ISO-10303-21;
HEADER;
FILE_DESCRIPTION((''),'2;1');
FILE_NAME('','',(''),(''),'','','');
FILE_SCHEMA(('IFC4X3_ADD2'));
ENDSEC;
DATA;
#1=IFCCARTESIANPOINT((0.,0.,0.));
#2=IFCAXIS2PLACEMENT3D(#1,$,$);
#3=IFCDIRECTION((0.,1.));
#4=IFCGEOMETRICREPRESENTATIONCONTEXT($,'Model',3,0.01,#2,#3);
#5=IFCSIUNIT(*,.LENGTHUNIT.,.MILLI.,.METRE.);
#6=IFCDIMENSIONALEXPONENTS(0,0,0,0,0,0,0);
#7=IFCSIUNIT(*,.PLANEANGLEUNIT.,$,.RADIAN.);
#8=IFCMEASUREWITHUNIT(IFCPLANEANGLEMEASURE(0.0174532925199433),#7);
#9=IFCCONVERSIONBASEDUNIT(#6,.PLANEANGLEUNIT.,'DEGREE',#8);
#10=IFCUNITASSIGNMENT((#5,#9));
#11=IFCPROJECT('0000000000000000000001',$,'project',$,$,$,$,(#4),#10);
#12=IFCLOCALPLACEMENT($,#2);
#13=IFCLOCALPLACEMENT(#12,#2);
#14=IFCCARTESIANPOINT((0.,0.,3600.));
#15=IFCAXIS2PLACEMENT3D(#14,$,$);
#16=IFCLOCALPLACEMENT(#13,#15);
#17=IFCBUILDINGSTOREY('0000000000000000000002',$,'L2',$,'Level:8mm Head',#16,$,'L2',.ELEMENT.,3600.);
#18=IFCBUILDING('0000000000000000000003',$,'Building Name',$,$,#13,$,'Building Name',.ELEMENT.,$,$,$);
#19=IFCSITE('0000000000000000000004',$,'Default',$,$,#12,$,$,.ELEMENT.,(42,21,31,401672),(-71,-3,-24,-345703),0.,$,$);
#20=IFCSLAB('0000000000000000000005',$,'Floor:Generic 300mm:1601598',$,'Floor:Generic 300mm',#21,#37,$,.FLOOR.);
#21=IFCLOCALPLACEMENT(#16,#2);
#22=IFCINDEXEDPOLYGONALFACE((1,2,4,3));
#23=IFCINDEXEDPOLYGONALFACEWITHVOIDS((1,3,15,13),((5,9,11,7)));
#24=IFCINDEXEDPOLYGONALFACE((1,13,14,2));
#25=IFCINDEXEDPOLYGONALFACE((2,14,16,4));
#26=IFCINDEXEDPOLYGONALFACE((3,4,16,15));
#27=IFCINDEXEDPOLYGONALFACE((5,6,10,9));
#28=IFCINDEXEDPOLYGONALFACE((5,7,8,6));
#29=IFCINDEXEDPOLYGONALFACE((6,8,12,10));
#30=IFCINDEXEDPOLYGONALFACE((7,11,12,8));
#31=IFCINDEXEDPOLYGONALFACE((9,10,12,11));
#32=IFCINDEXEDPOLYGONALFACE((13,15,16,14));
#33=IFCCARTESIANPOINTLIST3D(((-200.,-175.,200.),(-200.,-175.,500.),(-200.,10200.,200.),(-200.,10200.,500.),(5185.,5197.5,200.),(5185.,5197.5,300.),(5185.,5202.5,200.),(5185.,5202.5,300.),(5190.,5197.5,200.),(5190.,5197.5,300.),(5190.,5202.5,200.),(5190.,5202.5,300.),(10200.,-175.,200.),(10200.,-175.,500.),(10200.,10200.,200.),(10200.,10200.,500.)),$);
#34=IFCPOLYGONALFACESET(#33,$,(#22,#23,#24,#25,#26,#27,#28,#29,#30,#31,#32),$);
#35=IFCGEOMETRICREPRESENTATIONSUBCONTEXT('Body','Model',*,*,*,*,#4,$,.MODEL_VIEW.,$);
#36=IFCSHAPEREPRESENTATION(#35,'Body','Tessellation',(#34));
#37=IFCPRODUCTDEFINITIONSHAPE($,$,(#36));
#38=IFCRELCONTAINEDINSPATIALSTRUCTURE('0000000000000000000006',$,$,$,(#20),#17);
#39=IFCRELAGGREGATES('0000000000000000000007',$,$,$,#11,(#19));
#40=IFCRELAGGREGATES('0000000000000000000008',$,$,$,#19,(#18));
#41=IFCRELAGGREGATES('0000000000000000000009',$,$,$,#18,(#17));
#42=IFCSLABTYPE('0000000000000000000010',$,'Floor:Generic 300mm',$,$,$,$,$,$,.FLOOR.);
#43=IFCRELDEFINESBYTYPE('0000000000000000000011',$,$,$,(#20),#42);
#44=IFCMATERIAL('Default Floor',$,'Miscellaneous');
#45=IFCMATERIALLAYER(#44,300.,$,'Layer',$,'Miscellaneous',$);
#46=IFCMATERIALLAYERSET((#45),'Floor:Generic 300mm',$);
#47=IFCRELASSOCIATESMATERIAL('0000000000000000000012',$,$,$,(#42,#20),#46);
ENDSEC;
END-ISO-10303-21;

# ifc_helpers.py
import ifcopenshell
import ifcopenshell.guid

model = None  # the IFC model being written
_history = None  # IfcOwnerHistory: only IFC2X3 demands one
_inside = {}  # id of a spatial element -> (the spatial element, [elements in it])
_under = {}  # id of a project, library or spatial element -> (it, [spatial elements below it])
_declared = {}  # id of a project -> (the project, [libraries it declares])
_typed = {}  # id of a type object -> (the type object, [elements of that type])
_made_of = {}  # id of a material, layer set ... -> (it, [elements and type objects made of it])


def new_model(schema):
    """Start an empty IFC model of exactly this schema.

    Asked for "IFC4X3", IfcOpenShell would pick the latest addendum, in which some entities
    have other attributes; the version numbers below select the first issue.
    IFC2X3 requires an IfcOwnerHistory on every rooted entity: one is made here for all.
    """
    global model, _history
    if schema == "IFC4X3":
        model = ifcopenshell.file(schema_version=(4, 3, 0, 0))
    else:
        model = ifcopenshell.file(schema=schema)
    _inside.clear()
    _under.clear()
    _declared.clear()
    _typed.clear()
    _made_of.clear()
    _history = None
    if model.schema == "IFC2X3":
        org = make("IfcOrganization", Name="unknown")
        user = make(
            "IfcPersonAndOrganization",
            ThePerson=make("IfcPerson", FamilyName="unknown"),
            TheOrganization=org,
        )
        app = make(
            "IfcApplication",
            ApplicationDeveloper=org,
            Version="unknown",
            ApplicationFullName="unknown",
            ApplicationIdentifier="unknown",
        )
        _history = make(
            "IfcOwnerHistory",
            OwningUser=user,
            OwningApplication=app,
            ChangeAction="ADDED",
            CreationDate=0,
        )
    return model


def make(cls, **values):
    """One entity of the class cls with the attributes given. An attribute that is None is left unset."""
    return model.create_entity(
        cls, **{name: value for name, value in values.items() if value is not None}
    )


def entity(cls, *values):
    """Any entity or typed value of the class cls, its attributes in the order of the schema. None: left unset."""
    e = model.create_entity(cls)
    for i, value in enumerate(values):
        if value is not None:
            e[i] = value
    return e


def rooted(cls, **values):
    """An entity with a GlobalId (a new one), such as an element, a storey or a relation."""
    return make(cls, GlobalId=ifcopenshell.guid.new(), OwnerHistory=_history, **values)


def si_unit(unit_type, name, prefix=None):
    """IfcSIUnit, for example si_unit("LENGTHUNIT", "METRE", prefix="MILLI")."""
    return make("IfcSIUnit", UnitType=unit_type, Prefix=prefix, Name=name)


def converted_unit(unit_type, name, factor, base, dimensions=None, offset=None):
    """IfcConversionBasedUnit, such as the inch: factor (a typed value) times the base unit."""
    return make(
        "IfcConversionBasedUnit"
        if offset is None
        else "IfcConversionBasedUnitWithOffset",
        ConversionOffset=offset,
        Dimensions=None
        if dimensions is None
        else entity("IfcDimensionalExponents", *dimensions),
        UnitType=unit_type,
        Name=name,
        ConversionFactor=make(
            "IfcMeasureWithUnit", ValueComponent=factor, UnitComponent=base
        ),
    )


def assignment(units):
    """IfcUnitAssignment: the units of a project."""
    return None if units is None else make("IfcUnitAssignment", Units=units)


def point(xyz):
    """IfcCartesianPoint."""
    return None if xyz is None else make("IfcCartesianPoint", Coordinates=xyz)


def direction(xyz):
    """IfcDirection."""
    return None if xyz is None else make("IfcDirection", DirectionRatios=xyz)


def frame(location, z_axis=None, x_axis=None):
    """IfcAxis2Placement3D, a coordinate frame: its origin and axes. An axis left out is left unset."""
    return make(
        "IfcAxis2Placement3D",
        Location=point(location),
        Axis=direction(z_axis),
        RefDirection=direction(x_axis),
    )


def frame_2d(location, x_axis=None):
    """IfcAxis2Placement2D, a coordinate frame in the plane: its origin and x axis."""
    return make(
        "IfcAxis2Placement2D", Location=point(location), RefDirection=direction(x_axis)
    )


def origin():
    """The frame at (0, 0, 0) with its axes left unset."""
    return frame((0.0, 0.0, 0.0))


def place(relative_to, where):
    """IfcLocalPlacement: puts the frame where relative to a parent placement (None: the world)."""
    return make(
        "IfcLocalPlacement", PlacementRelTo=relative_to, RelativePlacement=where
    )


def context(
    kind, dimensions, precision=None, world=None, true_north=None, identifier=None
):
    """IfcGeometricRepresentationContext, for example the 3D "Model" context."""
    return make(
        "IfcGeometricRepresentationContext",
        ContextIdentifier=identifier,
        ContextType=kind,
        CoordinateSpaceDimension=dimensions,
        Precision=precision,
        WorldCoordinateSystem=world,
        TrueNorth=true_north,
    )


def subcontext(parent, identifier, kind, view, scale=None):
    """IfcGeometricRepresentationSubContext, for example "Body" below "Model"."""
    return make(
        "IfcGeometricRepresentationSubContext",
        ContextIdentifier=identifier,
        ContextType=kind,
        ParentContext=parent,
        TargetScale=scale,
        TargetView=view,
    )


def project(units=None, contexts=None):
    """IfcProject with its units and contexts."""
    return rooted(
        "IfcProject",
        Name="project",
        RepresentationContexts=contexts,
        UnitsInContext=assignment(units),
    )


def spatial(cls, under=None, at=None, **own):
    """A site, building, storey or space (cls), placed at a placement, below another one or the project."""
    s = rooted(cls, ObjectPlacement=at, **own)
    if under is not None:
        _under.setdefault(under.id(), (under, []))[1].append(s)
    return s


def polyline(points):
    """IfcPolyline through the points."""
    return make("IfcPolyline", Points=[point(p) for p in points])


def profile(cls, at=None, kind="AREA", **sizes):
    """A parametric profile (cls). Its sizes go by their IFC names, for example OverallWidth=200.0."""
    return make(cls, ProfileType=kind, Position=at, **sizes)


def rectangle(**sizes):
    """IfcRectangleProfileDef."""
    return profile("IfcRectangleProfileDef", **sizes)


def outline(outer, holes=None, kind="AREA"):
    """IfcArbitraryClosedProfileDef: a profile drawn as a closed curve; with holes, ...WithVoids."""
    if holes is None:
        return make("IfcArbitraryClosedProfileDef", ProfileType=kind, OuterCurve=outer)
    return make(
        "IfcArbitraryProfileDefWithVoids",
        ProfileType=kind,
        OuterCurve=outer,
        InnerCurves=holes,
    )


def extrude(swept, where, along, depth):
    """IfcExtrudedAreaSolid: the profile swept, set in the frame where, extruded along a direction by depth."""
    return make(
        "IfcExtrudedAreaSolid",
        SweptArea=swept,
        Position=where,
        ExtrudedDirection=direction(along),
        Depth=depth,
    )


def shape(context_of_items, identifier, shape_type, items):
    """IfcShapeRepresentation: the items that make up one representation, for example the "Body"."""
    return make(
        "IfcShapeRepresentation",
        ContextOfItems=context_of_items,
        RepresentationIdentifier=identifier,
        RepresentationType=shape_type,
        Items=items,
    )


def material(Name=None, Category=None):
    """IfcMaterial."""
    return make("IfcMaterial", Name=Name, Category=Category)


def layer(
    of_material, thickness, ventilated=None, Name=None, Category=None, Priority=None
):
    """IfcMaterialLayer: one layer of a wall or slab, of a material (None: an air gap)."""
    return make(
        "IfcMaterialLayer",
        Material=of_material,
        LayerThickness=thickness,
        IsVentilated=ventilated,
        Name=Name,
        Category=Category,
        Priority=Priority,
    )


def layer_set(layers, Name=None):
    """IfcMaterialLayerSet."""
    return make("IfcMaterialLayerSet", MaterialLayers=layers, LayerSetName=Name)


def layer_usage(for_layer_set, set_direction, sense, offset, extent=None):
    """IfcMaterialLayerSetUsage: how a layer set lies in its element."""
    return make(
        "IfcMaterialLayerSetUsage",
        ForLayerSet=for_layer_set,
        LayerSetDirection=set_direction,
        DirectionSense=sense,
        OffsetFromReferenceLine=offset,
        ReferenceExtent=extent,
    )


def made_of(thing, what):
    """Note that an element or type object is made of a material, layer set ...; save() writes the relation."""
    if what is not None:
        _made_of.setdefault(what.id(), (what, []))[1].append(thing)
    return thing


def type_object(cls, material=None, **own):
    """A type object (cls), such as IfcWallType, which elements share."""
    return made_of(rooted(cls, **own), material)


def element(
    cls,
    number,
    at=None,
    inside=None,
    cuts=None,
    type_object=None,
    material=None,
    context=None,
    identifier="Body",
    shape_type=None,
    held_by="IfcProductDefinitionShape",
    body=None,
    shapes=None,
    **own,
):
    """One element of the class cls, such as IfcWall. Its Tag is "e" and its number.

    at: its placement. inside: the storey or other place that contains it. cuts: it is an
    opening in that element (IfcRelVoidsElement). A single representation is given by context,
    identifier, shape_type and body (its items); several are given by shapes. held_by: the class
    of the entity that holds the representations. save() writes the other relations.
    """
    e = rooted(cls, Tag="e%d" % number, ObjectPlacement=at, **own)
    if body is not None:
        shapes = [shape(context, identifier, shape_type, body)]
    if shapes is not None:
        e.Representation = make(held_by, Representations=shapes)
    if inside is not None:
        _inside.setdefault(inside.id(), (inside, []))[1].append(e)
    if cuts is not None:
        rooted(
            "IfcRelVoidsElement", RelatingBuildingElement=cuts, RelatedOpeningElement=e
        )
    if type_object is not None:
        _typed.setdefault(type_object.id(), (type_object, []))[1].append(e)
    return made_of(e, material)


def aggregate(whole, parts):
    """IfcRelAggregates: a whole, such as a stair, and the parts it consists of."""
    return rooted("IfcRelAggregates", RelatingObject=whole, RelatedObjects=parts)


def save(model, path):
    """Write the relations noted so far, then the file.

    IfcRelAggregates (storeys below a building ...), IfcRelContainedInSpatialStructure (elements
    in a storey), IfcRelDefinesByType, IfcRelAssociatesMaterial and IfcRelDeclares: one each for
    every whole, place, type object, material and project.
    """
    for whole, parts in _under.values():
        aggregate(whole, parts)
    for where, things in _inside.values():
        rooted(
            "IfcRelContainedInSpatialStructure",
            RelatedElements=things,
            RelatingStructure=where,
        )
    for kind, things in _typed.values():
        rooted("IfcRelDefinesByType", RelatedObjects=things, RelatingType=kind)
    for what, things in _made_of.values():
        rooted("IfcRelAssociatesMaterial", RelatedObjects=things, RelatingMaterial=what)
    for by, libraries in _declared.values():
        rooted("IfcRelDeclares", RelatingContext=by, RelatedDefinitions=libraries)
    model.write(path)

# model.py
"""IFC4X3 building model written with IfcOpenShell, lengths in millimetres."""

from ifc_helpers import new_model, entity, si_unit, converted_unit, direction, frame, frame_2d, origin, place, context, subcontext, project, spatial, polyline, rectangle, outline, extrude, material, layer, layer_set, layer_usage, type_object, element, save


model = new_model("IFC4X3")

# Units and contexts
model_context = context("Model", 3, precision=0.01, world=origin(), true_north=direction((0.0, 1.0)))
body_context = subcontext(model_context, "Body", "Model", "MODEL_VIEW")
ifc_project = project(units=[si_unit("LENGTHUNIT", "METRE", prefix="MILLI"), converted_unit("PLANEANGLEUNIT", "DEGREE", entity("IfcPlaneAngleMeasure", 0.0174532925199433), si_unit("PLANEANGLEUNIT", "RADIAN"), dimensions=[0, 0, 0, 0, 0, 0, 0])], contexts=[model_context])

# Site, building, storey
site_placement = place(None, origin())
site = spatial("IfcSite", under=ifc_project, at=site_placement, Name="Default", CompositionType="ELEMENT", RefLatitude=(42, 21, 31, 401672), RefLongitude=(-71, -3, -24, -345703), RefElevation=0.0)
building_placement = place(site_placement, origin())
building = spatial("IfcBuilding", under=site, at=building_placement, Name="Building Name", LongName="Building Name", CompositionType="ELEMENT")
storey_placement = place(building_placement, frame((0.0, 0.0, 3600.0)))
storey = spatial("IfcBuildingStorey", under=building, at=storey_placement, Name="L2", ObjectType="Level:8mm Head", LongName="L2", CompositionType="ELEMENT", Elevation=3600.0)

# Slab, opening
ifc_material = material(Name="Default Floor", Category="Miscellaneous")
ifc_layer = layer(ifc_material, 300.0, Name="Layer", Category="Miscellaneous")
ifc_layer_set = layer_set([ifc_layer], Name="Floor:Generic 300mm")
ifc_layer_usage = layer_usage(ifc_layer_set, "AXIS3", "POSITIVE", 0.0)
slab_type = type_object("IfcSlabType", Name="Floor:Generic 300mm", PredefinedType="FLOOR", material=ifc_layer_set)
slab_placement = place(storey_placement, origin())
slab = element("IfcSlab", 1, at=slab_placement, inside=storey, type_object=slab_type, material=ifc_layer_usage, Name="Floor:Generic 300mm:1601598", ObjectType="Floor:Generic 300mm", PredefinedType="FLOOR", context=body_context, shape_type="SweptSolid", body=[
    extrude(rectangle(XDim=10375.0, YDim=10400.0, at=frame_2d((0.0, 0.0), x_axis=(1.0, 0.0))), frame((5000.0, 5012.5, 500.0), z_axis=(0.0, 0.0, -1.0), x_axis=(0.0, 1.0, 0.0)), (0.0, 0.0, 1.0), 300.0),
])
opening_placement = place(slab_placement, frame((5185.0, 5197.5, 0.0)))
element("IfcOpeningElement", 2, at=opening_placement, cuts=slab, context=model_context, shape_type="SweptSolid", body=[
    extrude(outline(polyline([(0.0, 0.0), (5.0, 0.0), (5.0, 5.0), (0.0, 5.0), (0.0, 0.0)])), origin(), (0.0, 0.0, 1.0), 300.0),
])

save(model, "model.ifc")
